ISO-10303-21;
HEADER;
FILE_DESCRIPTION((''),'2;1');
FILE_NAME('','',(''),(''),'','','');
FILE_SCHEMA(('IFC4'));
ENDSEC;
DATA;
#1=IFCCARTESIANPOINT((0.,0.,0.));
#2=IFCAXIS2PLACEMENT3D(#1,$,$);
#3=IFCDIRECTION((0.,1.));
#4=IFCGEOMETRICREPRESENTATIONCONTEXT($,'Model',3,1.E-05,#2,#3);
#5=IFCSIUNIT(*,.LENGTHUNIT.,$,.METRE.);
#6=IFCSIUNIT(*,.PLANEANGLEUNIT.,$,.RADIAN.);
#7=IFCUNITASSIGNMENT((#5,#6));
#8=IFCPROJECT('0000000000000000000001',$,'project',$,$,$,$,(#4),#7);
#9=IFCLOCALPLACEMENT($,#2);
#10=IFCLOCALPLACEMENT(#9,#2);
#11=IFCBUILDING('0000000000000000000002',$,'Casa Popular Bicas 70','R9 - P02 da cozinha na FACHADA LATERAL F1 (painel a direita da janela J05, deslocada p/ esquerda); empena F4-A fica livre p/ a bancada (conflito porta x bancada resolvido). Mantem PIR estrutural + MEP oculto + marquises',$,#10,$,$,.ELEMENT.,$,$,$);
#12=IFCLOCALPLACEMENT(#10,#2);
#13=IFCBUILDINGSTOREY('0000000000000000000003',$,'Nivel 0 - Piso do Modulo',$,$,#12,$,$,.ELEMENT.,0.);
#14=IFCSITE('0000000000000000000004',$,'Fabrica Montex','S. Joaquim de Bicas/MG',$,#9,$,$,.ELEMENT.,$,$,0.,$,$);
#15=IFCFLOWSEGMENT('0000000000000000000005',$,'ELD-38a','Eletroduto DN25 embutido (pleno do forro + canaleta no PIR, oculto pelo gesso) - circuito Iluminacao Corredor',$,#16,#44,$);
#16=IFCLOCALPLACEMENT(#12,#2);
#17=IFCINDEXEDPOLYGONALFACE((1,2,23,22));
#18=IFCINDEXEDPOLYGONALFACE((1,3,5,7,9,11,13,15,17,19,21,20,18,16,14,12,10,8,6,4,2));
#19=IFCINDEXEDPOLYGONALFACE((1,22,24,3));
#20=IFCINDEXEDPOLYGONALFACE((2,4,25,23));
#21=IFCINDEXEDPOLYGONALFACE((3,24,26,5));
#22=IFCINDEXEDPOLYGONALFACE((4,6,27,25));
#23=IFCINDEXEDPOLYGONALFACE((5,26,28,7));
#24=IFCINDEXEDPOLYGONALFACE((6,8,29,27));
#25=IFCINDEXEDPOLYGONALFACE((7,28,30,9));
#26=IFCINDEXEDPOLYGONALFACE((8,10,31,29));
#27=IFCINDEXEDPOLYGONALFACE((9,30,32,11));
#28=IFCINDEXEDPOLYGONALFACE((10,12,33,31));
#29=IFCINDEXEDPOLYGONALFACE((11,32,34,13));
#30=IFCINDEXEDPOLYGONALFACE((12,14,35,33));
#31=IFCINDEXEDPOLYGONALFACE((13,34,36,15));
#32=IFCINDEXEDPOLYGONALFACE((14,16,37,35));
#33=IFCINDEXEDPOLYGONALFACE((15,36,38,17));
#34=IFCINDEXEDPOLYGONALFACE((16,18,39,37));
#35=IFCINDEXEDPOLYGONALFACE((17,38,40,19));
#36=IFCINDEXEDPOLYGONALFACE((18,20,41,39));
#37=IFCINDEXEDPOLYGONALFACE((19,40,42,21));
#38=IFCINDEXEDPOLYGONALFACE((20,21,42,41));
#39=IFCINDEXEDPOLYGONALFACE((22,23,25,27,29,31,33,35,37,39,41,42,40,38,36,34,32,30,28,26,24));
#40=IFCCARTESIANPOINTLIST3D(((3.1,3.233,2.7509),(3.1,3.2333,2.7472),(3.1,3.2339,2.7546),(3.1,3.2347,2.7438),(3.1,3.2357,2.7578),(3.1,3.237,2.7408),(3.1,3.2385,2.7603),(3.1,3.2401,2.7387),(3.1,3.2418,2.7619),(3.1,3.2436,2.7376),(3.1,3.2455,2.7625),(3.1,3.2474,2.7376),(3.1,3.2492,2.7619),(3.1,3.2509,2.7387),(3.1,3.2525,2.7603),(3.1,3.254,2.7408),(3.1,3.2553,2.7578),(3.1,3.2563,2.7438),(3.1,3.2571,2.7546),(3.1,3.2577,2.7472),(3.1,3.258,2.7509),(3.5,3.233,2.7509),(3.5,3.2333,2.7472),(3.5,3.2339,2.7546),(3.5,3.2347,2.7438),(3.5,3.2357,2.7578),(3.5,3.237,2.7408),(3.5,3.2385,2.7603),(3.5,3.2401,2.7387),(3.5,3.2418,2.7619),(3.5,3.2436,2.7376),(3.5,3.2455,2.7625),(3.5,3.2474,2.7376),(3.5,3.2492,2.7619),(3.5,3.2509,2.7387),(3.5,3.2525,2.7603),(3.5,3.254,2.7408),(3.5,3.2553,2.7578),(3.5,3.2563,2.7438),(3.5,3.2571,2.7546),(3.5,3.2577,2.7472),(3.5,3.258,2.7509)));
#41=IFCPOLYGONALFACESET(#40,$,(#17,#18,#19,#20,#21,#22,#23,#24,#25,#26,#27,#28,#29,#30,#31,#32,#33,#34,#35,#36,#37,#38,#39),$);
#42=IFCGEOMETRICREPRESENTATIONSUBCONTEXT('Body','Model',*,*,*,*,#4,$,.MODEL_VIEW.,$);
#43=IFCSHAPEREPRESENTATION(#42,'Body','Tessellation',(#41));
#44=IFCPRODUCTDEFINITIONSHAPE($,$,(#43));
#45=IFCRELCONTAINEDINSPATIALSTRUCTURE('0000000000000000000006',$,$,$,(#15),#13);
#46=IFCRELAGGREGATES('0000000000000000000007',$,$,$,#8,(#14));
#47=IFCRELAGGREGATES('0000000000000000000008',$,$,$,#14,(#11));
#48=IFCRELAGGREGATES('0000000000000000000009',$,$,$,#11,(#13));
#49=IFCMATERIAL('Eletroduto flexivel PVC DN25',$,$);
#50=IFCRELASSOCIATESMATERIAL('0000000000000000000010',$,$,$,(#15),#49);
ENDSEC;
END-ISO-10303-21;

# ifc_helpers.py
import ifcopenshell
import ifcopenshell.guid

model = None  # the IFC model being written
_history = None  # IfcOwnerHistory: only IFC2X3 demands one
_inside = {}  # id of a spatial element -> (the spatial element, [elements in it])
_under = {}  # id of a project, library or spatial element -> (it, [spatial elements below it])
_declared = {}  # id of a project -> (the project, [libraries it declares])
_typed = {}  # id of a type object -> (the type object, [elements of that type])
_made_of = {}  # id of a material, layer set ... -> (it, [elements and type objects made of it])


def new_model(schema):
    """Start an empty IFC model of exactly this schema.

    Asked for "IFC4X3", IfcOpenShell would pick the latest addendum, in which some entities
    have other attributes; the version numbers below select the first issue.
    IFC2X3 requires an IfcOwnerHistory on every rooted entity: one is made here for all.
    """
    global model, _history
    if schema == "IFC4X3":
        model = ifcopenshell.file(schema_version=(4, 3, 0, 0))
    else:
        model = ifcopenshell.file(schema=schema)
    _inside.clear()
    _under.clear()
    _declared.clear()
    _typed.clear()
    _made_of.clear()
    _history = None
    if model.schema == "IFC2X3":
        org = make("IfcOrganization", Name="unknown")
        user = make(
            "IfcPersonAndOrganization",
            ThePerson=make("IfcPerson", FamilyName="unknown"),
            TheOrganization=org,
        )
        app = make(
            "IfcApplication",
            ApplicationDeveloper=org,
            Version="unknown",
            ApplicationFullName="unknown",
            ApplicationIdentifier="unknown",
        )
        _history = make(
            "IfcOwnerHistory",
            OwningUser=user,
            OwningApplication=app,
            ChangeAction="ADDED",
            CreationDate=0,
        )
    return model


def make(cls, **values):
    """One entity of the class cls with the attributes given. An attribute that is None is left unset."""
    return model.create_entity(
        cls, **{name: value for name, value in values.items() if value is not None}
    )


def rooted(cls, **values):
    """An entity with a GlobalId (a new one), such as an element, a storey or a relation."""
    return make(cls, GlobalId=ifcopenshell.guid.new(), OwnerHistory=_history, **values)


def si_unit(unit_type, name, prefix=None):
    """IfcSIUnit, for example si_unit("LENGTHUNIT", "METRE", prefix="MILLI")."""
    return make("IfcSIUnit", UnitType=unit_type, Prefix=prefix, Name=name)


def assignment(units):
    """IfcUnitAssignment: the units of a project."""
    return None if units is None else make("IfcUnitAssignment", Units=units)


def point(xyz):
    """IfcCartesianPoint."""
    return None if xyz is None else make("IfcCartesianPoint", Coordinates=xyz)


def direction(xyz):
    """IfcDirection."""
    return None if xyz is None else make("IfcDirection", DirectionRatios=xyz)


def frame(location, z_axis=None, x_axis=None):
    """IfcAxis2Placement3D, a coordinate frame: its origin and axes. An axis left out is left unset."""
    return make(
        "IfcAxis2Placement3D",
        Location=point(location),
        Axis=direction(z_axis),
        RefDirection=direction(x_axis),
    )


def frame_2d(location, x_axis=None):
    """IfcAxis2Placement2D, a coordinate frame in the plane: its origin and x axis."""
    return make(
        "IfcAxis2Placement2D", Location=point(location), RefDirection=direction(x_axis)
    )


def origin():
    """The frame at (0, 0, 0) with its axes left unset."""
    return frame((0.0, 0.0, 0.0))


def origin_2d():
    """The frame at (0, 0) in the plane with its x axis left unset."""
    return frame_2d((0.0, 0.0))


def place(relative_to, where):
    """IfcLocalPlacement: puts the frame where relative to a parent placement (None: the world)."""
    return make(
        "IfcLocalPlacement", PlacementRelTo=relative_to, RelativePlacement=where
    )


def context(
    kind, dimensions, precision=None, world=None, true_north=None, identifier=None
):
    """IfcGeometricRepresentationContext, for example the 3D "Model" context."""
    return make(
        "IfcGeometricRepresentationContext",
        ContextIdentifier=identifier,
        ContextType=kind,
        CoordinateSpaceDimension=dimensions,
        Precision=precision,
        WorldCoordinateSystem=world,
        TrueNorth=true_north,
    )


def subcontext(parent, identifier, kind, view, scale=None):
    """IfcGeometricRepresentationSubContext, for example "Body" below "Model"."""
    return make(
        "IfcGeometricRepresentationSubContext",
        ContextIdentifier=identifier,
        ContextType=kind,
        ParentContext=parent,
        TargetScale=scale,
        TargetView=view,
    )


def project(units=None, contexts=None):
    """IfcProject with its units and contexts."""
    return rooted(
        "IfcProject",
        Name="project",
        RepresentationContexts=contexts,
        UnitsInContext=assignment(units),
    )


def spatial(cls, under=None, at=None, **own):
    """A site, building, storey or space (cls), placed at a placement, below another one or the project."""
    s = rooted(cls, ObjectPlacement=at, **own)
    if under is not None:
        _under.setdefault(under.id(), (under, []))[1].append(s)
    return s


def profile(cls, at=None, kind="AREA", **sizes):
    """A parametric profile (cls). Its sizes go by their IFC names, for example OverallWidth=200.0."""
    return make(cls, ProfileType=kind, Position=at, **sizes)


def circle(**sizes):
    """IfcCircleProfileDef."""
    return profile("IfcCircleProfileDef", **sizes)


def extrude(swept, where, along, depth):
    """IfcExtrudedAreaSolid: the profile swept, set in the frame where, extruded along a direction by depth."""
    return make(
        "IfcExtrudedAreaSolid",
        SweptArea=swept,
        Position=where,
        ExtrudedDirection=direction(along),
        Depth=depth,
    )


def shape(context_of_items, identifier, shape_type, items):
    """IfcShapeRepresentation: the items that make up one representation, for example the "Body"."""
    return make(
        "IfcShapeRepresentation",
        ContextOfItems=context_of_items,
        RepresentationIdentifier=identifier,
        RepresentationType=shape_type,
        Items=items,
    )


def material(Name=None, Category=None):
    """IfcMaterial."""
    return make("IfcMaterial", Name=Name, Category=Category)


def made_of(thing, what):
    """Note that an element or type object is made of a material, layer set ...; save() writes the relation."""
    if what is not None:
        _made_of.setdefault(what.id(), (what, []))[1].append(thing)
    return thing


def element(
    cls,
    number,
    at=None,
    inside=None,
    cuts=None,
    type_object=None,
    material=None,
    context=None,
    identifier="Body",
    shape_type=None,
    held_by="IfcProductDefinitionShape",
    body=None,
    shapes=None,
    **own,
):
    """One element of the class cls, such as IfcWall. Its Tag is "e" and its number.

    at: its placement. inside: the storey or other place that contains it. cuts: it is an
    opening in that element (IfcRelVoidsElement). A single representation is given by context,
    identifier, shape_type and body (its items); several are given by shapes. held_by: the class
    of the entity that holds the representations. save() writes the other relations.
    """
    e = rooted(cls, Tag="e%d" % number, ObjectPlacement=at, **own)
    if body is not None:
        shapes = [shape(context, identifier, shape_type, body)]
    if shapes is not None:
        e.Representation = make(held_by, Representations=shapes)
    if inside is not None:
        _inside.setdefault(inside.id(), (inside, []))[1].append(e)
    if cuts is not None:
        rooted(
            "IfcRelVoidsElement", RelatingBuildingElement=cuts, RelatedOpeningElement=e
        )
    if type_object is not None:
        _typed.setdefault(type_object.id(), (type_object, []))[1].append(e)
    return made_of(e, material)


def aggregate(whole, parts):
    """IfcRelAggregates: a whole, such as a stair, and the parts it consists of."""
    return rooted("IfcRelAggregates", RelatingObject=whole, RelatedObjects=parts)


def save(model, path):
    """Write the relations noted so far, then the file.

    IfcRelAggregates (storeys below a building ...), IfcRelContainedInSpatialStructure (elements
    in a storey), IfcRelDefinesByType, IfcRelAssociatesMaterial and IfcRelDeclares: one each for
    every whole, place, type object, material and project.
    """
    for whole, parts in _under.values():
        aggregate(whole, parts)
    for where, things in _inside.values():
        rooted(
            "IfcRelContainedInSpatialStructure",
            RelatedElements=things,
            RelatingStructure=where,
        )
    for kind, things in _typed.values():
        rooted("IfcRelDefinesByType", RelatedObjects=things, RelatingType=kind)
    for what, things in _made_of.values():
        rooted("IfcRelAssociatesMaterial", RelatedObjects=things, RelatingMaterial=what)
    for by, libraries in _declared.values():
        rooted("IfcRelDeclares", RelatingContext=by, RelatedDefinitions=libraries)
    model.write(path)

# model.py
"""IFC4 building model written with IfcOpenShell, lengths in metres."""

from ifc_helpers import new_model, si_unit, direction, frame, origin, origin_2d, place, context, subcontext, project, spatial, circle, extrude, material, element, save


model = new_model("IFC4")

# Units and contexts
model_context = context("Model", 3, precision=1e-05, world=origin(), true_north=direction((0.0, 1.0)))
body_context = subcontext(model_context, "Body", "Model", "MODEL_VIEW")
ifc_project = project(units=[si_unit("LENGTHUNIT", "METRE"), si_unit("PLANEANGLEUNIT", "RADIAN")], contexts=[model_context])

# Site, building, storey
site_placement = place(None, origin())
site = spatial("IfcSite", under=ifc_project, at=site_placement, Name="Fabrica Montex", Description="S. Joaquim de Bicas/MG", CompositionType="ELEMENT", RefElevation=0.0)
building_placement = place(site_placement, origin())
building = spatial("IfcBuilding", under=site, at=building_placement, Name="Casa Popular Bicas 70", Description="R9 - P02 da cozinha na FACHADA LATERAL F1 (painel a direita da janela J05, deslocada p/ esquerda); empena F4-A fica livre p/ a bancada (conflito porta x bancada resolvido). Mantem PIR estrutural + MEP oculto + marquises", CompositionType="ELEMENT")
storey_placement = place(building_placement, origin())
storey = spatial("IfcBuildingStorey", under=building, at=storey_placement, Name="Nivel 0 - Piso do Modulo", CompositionType="ELEMENT", Elevation=0.0)

# Flow segment
ifc_material_1 = material(Name="Eletroduto flexivel PVC DN25")
flow_segment_1_placement = place(storey_placement, frame((3.5, 3.2455, 2.75), z_axis=(-1.0, 0.0, 0.0), x_axis=(0.0, 0.0, 1.0)))
element("IfcFlowSegment", 1, at=flow_segment_1_placement, inside=storey, material=ifc_material_1, Name="ELD-38a", Description="Eletroduto DN25 embutido (pleno do forro + canaleta no PIR, oculto pelo gesso) - circuito Iluminacao Corredor", context=body_context, shape_type="SweptSolid", body=[
    extrude(circle(Radius=0.0125, at=origin_2d()), origin(), (0.0, 0.0, 1.0), 0.4),
])

save(model, "model.ifc")
